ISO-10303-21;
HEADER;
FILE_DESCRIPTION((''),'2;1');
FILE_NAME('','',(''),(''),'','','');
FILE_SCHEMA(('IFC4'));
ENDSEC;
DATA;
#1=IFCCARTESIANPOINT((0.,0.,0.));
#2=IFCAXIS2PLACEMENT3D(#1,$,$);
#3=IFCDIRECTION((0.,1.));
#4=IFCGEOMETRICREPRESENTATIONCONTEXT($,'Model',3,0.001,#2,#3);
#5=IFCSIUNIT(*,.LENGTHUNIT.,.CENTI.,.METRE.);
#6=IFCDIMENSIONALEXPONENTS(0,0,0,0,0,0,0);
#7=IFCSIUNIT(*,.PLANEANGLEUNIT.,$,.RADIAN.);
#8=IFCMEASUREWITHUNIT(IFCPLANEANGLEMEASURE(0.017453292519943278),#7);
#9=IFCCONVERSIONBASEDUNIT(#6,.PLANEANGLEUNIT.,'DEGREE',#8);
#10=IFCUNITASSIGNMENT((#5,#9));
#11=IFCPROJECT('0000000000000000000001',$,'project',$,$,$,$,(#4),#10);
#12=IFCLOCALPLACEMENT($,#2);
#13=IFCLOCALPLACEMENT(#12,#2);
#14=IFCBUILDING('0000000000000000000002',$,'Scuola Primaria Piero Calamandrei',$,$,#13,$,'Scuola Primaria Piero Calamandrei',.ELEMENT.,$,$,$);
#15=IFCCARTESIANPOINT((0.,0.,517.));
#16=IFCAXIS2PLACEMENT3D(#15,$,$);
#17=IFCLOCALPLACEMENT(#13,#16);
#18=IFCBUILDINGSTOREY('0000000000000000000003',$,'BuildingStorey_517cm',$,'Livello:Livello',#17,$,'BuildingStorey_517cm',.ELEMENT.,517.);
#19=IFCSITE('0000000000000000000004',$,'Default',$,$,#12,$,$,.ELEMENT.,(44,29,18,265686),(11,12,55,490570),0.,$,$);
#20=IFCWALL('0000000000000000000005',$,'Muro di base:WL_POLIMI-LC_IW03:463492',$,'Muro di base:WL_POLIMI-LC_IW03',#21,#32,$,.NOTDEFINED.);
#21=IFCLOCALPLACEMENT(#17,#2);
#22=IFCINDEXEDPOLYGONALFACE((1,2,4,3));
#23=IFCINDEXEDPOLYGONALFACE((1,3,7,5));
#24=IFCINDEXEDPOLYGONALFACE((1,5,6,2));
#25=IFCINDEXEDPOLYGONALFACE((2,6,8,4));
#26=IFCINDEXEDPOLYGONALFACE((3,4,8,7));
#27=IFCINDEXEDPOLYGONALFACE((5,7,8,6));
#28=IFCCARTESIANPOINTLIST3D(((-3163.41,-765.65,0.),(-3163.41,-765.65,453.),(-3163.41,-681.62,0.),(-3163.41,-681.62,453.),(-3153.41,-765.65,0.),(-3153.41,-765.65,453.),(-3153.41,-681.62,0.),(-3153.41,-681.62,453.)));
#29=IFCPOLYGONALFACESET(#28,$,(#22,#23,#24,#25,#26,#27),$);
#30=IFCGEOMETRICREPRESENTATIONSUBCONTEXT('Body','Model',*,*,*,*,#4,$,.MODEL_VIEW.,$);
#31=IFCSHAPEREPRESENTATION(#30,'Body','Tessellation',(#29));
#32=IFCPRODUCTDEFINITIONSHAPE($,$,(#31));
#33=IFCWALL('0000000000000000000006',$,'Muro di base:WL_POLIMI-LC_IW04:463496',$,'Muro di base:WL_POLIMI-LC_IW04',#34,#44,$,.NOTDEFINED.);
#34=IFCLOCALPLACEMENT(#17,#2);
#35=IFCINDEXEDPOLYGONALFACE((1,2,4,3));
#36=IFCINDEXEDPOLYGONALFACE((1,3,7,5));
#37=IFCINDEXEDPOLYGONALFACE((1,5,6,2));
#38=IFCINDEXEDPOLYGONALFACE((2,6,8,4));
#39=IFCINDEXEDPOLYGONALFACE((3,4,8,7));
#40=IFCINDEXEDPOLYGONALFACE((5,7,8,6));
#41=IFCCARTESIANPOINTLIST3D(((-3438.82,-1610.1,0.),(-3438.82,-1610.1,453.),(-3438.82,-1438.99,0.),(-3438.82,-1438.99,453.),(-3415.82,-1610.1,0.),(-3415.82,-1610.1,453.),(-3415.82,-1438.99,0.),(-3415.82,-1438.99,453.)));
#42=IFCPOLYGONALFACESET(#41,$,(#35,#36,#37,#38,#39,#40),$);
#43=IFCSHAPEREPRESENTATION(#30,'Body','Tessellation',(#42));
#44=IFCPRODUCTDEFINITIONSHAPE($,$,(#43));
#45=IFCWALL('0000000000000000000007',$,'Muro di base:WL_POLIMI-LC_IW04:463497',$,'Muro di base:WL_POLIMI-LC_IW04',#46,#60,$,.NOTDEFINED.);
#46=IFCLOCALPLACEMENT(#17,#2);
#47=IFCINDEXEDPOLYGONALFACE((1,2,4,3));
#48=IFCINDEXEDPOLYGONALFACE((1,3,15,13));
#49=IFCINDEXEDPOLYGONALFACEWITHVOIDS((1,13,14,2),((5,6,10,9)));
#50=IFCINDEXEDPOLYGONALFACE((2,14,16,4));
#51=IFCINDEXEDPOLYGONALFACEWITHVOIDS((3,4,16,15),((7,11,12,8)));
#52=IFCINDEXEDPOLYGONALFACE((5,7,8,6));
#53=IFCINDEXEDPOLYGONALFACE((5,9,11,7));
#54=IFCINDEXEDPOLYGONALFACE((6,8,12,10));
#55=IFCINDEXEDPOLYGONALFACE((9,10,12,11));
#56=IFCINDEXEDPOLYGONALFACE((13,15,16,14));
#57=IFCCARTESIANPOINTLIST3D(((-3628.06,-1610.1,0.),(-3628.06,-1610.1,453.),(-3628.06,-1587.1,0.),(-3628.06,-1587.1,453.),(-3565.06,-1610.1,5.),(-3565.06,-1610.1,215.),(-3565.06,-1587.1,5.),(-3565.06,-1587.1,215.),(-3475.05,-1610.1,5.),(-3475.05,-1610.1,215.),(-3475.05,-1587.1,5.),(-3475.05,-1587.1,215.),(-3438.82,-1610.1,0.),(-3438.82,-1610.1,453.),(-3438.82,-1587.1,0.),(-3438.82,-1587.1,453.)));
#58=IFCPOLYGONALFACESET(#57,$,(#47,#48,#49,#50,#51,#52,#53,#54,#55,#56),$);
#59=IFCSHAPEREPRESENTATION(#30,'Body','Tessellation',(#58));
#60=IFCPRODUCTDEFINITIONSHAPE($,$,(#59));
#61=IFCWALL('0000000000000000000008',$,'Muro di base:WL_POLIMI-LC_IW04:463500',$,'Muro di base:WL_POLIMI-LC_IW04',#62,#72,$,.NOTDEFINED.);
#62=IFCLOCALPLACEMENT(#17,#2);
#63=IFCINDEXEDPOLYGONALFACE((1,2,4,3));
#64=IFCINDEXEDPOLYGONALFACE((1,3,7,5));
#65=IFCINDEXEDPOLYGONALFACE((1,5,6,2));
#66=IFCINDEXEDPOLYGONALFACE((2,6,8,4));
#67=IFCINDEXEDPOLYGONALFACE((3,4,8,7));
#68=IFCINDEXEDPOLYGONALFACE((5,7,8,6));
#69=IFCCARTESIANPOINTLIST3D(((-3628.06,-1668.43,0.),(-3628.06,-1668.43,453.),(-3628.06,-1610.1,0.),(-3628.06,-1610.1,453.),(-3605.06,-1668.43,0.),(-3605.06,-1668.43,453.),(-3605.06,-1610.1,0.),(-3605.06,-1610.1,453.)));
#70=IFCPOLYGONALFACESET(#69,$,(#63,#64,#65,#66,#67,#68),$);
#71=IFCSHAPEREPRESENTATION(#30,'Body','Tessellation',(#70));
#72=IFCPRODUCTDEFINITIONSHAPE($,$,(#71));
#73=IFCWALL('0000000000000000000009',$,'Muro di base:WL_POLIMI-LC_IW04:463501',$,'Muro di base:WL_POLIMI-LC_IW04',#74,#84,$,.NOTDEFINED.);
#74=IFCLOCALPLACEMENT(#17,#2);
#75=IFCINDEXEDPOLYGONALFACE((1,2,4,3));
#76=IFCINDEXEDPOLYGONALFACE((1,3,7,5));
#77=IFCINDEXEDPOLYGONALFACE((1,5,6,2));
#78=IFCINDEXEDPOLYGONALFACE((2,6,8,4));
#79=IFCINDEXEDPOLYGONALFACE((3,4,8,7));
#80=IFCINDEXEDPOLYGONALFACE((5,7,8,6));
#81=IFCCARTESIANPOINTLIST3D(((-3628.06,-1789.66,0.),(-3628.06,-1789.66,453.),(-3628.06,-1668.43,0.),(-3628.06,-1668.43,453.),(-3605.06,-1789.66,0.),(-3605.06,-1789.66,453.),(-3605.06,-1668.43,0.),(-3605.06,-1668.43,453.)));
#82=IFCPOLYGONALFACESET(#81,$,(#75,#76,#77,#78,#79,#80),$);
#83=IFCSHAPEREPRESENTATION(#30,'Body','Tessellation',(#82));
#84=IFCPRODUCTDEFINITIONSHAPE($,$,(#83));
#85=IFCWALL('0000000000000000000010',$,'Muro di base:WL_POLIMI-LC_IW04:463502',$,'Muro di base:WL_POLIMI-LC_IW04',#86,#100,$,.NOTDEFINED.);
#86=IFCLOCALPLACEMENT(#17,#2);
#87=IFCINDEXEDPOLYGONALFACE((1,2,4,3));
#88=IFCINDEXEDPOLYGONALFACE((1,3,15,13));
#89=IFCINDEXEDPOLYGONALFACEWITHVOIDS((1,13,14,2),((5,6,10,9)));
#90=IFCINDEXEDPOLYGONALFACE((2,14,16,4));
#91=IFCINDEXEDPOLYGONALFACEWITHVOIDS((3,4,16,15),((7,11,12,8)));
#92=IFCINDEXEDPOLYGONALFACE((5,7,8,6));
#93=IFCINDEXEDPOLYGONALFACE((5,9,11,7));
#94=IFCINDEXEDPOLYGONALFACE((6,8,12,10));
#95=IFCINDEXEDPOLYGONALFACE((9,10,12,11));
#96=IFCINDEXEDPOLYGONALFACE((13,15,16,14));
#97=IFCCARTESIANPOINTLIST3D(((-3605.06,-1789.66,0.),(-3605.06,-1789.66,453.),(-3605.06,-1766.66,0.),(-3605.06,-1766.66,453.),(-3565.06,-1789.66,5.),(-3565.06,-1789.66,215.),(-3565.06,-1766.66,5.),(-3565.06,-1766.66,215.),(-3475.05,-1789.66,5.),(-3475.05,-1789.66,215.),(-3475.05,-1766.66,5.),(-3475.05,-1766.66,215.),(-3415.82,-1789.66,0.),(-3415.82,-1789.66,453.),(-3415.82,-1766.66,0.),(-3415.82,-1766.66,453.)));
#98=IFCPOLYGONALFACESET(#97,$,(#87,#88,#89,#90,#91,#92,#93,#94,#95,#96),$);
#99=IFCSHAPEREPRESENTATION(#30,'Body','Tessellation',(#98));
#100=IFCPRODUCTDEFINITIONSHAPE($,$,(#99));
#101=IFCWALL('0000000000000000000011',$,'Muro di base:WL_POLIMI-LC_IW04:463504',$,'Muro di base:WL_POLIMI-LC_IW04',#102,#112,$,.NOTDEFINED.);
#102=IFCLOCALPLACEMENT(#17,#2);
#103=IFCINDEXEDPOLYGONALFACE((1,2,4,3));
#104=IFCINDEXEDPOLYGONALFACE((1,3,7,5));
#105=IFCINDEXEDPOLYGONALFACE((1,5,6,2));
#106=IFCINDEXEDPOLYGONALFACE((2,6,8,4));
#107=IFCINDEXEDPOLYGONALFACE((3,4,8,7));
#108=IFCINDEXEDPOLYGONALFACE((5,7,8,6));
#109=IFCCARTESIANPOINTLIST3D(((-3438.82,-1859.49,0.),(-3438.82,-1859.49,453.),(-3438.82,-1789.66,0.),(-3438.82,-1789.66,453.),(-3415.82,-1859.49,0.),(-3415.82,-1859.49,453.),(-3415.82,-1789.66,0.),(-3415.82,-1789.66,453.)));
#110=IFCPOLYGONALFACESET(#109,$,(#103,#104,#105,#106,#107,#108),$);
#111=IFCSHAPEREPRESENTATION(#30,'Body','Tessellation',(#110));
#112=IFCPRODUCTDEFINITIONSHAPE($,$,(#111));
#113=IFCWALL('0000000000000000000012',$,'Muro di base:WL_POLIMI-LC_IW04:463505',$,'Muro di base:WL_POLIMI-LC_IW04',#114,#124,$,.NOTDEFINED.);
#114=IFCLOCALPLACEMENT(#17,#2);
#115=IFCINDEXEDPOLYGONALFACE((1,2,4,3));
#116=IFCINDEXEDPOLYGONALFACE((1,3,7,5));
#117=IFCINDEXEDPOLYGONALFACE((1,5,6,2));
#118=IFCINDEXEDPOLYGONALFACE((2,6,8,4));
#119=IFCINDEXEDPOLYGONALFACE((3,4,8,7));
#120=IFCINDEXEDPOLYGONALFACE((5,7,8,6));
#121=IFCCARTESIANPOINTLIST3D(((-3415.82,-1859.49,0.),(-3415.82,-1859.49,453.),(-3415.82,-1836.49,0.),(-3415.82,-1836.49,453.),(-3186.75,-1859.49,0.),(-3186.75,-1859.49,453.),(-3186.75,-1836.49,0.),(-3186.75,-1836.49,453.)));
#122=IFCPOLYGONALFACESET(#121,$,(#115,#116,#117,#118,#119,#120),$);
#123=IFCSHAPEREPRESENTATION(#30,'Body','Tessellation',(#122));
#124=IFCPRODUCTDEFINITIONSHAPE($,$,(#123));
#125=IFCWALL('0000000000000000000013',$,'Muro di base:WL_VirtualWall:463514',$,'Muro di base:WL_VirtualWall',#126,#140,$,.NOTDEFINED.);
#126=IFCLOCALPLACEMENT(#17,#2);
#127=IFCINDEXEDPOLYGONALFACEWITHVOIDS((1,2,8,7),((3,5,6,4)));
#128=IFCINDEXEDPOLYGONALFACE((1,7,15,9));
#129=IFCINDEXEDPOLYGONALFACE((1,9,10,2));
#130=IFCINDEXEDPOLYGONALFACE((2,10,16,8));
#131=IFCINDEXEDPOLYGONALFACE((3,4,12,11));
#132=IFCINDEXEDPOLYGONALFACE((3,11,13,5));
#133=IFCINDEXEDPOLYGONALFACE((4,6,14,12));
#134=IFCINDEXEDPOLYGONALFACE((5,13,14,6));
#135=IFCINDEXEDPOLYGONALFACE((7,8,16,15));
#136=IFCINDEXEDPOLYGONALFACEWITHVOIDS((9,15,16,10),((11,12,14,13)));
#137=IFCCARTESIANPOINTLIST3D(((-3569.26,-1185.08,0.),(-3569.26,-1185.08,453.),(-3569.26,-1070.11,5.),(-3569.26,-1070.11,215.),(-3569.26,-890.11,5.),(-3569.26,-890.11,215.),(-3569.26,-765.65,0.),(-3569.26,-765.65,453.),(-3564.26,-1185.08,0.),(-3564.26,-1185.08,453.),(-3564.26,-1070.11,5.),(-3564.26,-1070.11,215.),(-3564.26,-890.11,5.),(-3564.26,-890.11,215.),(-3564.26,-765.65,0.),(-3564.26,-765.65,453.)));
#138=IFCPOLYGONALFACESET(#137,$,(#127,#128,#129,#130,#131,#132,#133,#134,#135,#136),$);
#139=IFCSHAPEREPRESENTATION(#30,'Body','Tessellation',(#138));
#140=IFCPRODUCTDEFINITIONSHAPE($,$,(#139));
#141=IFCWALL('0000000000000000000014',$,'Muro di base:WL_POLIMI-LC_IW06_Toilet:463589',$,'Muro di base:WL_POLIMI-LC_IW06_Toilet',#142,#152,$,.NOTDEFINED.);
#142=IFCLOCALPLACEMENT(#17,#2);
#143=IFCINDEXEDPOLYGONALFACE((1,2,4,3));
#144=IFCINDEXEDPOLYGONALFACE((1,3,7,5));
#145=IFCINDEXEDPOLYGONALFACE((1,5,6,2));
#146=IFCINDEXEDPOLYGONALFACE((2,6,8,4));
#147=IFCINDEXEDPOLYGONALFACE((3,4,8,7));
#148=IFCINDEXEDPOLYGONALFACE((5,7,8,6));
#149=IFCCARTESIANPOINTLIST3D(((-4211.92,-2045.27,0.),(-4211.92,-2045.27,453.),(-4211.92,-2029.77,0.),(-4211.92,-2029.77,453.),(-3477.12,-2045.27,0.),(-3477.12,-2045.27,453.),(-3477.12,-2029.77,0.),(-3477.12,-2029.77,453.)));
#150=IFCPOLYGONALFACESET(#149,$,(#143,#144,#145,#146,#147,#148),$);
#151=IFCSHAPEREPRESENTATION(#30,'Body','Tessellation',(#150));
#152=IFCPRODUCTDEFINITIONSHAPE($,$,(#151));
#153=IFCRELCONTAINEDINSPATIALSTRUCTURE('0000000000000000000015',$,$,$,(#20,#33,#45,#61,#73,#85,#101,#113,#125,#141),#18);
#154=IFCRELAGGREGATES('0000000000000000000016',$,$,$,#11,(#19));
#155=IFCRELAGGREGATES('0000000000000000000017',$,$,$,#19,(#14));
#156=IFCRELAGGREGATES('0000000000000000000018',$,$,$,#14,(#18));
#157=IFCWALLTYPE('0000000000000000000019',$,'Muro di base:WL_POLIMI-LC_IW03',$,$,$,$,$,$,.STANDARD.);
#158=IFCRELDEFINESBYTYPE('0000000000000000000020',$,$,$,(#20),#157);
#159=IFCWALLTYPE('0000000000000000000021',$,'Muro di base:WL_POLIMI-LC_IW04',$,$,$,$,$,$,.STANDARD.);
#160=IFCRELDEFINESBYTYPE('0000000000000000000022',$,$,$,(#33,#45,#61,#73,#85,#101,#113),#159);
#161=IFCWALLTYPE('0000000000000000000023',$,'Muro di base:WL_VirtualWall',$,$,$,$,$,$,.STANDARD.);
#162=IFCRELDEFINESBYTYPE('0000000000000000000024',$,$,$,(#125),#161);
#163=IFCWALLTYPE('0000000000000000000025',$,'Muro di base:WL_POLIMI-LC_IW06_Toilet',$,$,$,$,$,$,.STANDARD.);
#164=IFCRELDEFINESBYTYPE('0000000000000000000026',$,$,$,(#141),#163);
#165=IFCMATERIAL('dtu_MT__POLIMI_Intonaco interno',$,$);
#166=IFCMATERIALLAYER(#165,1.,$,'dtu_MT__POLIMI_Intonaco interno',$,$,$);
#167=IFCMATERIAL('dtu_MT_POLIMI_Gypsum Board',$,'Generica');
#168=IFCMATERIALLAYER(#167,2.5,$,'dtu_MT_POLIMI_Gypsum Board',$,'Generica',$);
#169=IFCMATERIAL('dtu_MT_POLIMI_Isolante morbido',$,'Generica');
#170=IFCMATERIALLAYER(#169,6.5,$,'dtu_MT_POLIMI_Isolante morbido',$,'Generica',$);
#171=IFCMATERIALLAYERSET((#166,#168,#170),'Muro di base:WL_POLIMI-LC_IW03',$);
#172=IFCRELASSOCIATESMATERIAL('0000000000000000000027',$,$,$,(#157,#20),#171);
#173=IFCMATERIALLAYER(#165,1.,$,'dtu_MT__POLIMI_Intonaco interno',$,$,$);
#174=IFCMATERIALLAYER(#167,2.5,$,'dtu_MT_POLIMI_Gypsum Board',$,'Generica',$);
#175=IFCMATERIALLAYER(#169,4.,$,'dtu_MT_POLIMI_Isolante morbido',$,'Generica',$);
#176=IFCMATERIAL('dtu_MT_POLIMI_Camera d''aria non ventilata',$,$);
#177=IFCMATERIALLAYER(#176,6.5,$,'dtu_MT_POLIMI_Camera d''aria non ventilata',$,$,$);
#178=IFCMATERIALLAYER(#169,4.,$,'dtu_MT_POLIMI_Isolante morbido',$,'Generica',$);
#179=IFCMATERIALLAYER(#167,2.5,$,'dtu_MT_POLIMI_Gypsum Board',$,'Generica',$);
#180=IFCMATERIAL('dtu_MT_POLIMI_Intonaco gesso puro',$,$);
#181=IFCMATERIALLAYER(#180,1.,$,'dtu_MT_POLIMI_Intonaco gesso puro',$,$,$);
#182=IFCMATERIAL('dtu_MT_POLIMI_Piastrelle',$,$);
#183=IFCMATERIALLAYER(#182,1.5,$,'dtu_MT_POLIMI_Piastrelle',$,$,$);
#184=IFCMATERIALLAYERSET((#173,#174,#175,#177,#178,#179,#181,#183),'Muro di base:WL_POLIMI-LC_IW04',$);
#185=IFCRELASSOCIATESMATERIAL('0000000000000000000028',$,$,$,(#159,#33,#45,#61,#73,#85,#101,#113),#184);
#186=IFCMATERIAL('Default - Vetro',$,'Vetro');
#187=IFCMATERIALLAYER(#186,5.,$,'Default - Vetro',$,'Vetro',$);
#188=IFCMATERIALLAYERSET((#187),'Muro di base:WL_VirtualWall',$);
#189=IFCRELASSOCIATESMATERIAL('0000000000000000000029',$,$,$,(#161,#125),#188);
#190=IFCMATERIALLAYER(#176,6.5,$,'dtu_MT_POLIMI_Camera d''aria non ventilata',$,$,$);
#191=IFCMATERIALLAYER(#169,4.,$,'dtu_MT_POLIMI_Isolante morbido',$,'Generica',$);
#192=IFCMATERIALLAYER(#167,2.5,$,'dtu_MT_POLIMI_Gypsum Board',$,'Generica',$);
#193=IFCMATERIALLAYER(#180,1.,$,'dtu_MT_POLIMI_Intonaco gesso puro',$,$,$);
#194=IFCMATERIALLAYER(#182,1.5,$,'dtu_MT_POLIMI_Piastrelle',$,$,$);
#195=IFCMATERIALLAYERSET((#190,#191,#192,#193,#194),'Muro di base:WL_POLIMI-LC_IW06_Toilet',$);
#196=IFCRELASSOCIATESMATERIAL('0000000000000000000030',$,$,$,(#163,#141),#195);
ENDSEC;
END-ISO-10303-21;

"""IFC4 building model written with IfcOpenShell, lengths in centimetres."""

from ifc_helpers import new_model, entity, si_unit, converted_unit, direction, frame, frame_2d, origin, place, context, subcontext, project, spatial, rectangle, extrude, material, layer, layer_set, layer_usage, type_object, element, save


model = new_model("IFC4")

# Units and contexts
model_context = context("Model", 3, precision=0.001, world=origin(), true_north=direction((0.0, 1.0)))
body_context = subcontext(model_context, "Body", "Model", "MODEL_VIEW")
ifc_project = project(units=[si_unit("LENGTHUNIT", "METRE", prefix="CENTI"), converted_unit("PLANEANGLEUNIT", "DEGREE", entity("IfcPlaneAngleMeasure", 0.017453292519943278), si_unit("PLANEANGLEUNIT", "RADIAN"), dimensions=[0, 0, 0, 0, 0, 0, 0])], contexts=[model_context])

# Site, building, storey
site_placement = place(None, origin())
site = spatial("IfcSite", under=ifc_project, at=site_placement, Name="Default", CompositionType="ELEMENT", RefLatitude=(44, 29, 18, 265686), RefLongitude=(11, 12, 55, 490570), RefElevation=0.0)
building_placement = place(site_placement, origin())
building = spatial("IfcBuilding", under=site, at=building_placement, Name="Scuola Primaria Piero Calamandrei", LongName="Scuola Primaria Piero Calamandrei", CompositionType="ELEMENT")
storey_placement = place(building_placement, frame((0.0, 0.0, 517.0)))
storey = spatial("IfcBuildingStorey", under=building, at=storey_placement, Name="BuildingStorey_517cm", ObjectType="Livello:Livello", LongName="BuildingStorey_517cm", CompositionType="ELEMENT", Elevation=517.0)

# Shared definitions
ifc_material_1 = material(Name="dtu_MT_POLIMI_Isolante morbido", Category="Generica")
ifc_material_2 = material(Name="dtu_MT_POLIMI_Gypsum Board", Category="Generica")
ifc_material_3 = material(Name="dtu_MT__POLIMI_Intonaco interno")

# Shared definitions
ifc_material_4 = material(Name="dtu_MT_POLIMI_Camera d'aria non ventilata")
ifc_material_5 = material(Name="dtu_MT_POLIMI_Intonaco gesso puro")

# Walls
ifc_layer_1 = layer(ifc_material_3, 1.0, Name="dtu_MT__POLIMI_Intonaco interno")
ifc_layer_2 = layer(ifc_material_2, 2.5, Name="dtu_MT_POLIMI_Gypsum Board", Category="Generica")
ifc_layer_3 = layer(ifc_material_1, 6.5, Name="dtu_MT_POLIMI_Isolante morbido", Category="Generica")
ifc_layer_set_1 = layer_set([ifc_layer_1, ifc_layer_2, ifc_layer_3], Name="Muro di base:WL_POLIMI-LC_IW03")
wall_type_1 = type_object("IfcWallType", Name="Muro di base:WL_POLIMI-LC_IW03", PredefinedType="STANDARD", material=ifc_layer_set_1)
ifc_layer_usage_1 = layer_usage(ifc_layer_set_1, "AXIS2", "NEGATIVE", 5.0)
wall_1_placement = place(storey_placement, frame((-3158.41, -765.65, 0.0), z_axis=(0.0, 0.0, 1.0), x_axis=(0.0, 1.0, 0.0)))
element("IfcWall", 1, at=wall_1_placement, inside=storey, type_object=wall_type_1, material=ifc_layer_usage_1, Name="Muro di base:WL_POLIMI-LC_IW03:463492", ObjectType="Muro di base:WL_POLIMI-LC_IW03", PredefinedType="NOTDEFINED", context=body_context, shape_type="SweptSolid", body=[
    extrude(rectangle(XDim=84.03, YDim=10.0, at=frame_2d((42.02, 0.0), x_axis=(-1.0, 0.0))), origin(), (0.0, 0.0, 1.0), 453.0),
])
ifc_layer_4 = layer(ifc_material_3, 1.0, Name="dtu_MT__POLIMI_Intonaco interno")
ifc_layer_5 = layer(ifc_material_2, 2.5, Name="dtu_MT_POLIMI_Gypsum Board", Category="Generica")
ifc_layer_6 = layer(ifc_material_1, 4.0, Name="dtu_MT_POLIMI_Isolante morbido", Category="Generica")
ifc_layer_7 = layer(ifc_material_4, 6.5, Name="dtu_MT_POLIMI_Camera d'aria non ventilata")
ifc_layer_8 = layer(ifc_material_1, 4.0, Name="dtu_MT_POLIMI_Isolante morbido", Category="Generica")
ifc_layer_9 = layer(ifc_material_2, 2.5, Name="dtu_MT_POLIMI_Gypsum Board", Category="Generica")
ifc_layer_10 = layer(ifc_material_5, 1.0, Name="dtu_MT_POLIMI_Intonaco gesso puro")
ifc_material_6 = material(Name="dtu_MT_POLIMI_Piastrelle")
ifc_layer_11 = layer(ifc_material_6, 1.5, Name="dtu_MT_POLIMI_Piastrelle")
ifc_layer_set_2 = layer_set([ifc_layer_4, ifc_layer_5, ifc_layer_6, ifc_layer_7, ifc_layer_8, ifc_layer_9, ifc_layer_10, ifc_layer_11], Name="Muro di base:WL_POLIMI-LC_IW04")
ifc_layer_usage_2 = layer_usage(ifc_layer_set_2, "AXIS2", "NEGATIVE", 11.5)
wall_type_2 = type_object("IfcWallType", Name="Muro di base:WL_POLIMI-LC_IW04", PredefinedType="STANDARD", material=ifc_layer_set_2)
wall_2_placement = place(storey_placement, frame((-3427.32, -1610.1, 0.0), z_axis=(0.0, 0.0, 1.0), x_axis=(0.0, 1.0, 0.0)))
element("IfcWall", 2, at=wall_2_placement, inside=storey, type_object=wall_type_2, material=ifc_layer_usage_2, Name="Muro di base:WL_POLIMI-LC_IW04:463496", ObjectType="Muro di base:WL_POLIMI-LC_IW04", PredefinedType="NOTDEFINED", context=body_context, shape_type="SweptSolid", body=[
    extrude(rectangle(XDim=171.11, YDim=23.0, at=frame_2d((85.55, 0.0), x_axis=(-1.0, 0.0))), origin(), (0.0, 0.0, 1.0), 453.0),
])

# Wall, opening
ifc_layer_usage_3 = layer_usage(ifc_layer_set_2, "AXIS2", "NEGATIVE", 11.5)
wall_3_placement = place(storey_placement, frame((-3628.06, -1598.6, 0.0)))
wall_3 = element("IfcWall", 3, at=wall_3_placement, inside=storey, type_object=wall_type_2, material=ifc_layer_usage_3, Name="Muro di base:WL_POLIMI-LC_IW04:463497", ObjectType="Muro di base:WL_POLIMI-LC_IW04", PredefinedType="NOTDEFINED", context=body_context, shape_type="SweptSolid", body=[
    extrude(rectangle(XDim=189.23, YDim=23.0, at=frame_2d((94.62, 0.0), x_axis=(-1.0, 0.0))), origin(), (0.0, 0.0, 1.0), 453.0),
])
opening_1_placement = place(wall_3_placement, frame((153.0, 11.5, 5.0)))
element("IfcOpeningElement", 4, at=opening_1_placement, cuts=wall_3, PredefinedType="OPENING", context=body_context, shape_type="SweptSolid", body=[
    extrude(rectangle(XDim=210.0, YDim=90.0, at=frame_2d((105.0, 45.0), x_axis=(-1.0, 0.0))), frame((0.0, 0.0, 0.0), z_axis=(0.0, -1.0, 0.0), x_axis=(0.0, 0.0, 1.0)), (0.0, 0.0, 1.0), 23.0),
])

# Walls
ifc_layer_usage_4 = layer_usage(ifc_layer_set_2, "AXIS2", "NEGATIVE", 11.5)
wall_4_placement = place(storey_placement, frame((-3616.56, -1668.43, 0.0), z_axis=(0.0, 0.0, 1.0), x_axis=(0.0, 1.0, 0.0)))
element("IfcWall", 5, at=wall_4_placement, inside=storey, type_object=wall_type_2, material=ifc_layer_usage_4, Name="Muro di base:WL_POLIMI-LC_IW04:463500", ObjectType="Muro di base:WL_POLIMI-LC_IW04", PredefinedType="NOTDEFINED", context=body_context, shape_type="SweptSolid", body=[
    extrude(rectangle(XDim=58.33, YDim=23.0, at=frame_2d((29.16, 0.0), x_axis=(-1.0, 0.0))), origin(), (0.0, 0.0, 1.0), 453.0),
])
ifc_layer_usage_5 = layer_usage(ifc_layer_set_2, "AXIS2", "NEGATIVE", 11.5)
wall_5_placement = place(storey_placement, frame((-3616.56, -1789.66, 0.0), z_axis=(0.0, 0.0, 1.0), x_axis=(0.0, 1.0, 0.0)))
element("IfcWall", 6, at=wall_5_placement, inside=storey, type_object=wall_type_2, material=ifc_layer_usage_5, Name="Muro di base:WL_POLIMI-LC_IW04:463501", ObjectType="Muro di base:WL_POLIMI-LC_IW04", PredefinedType="NOTDEFINED", context=body_context, shape_type="SweptSolid", body=[
    extrude(rectangle(XDim=121.23, YDim=23.0, at=frame_2d((60.62, 0.0), x_axis=(-1.0, 0.0))), origin(), (0.0, 0.0, 1.0), 453.0),
])

# Wall, opening
ifc_layer_usage_6 = layer_usage(ifc_layer_set_2, "AXIS2", "NEGATIVE", 11.5)
wall_6_placement = place(storey_placement, frame((-3415.82, -1778.16, 0.0), z_axis=(0.0, 0.0, 1.0), x_axis=(-1.0, 0.0, 0.0)))
wall_6 = element("IfcWall", 7, at=wall_6_placement, inside=storey, type_object=wall_type_2, material=ifc_layer_usage_6, Name="Muro di base:WL_POLIMI-LC_IW04:463502", ObjectType="Muro di base:WL_POLIMI-LC_IW04", PredefinedType="NOTDEFINED", context=body_context, shape_type="SweptSolid", body=[
    extrude(rectangle(XDim=189.23, YDim=23.0, at=frame_2d((94.62, 0.0), x_axis=(-1.0, 0.0))), origin(), (0.0, 0.0, 1.0), 453.0),
])
opening_2_placement = place(wall_6_placement, frame((149.23, 11.5, 5.0)))
element("IfcOpeningElement", 8, at=opening_2_placement, cuts=wall_6, PredefinedType="OPENING", context=body_context, shape_type="SweptSolid", body=[
    extrude(rectangle(XDim=210.0, YDim=90.0, at=frame_2d((105.0, 45.0), x_axis=(-1.0, 0.0))), frame((0.0, 0.0, 0.0), z_axis=(0.0, -1.0, 0.0), x_axis=(0.0, 0.0, 1.0)), (0.0, 0.0, 1.0), 23.0),
])

# Walls
ifc_layer_usage_7 = layer_usage(ifc_layer_set_2, "AXIS2", "NEGATIVE", 11.5)
wall_7_placement = place(storey_placement, frame((-3427.32, -1859.49, 0.0), z_axis=(0.0, 0.0, 1.0), x_axis=(0.0, 1.0, 0.0)))
element("IfcWall", 9, at=wall_7_placement, inside=storey, type_object=wall_type_2, material=ifc_layer_usage_7, Name="Muro di base:WL_POLIMI-LC_IW04:463504", ObjectType="Muro di base:WL_POLIMI-LC_IW04", PredefinedType="NOTDEFINED", context=body_context, shape_type="SweptSolid", body=[
    extrude(rectangle(XDim=69.83, YDim=23.0, at=frame_2d((34.91, 0.0), x_axis=(-1.0, 0.0))), origin(), (0.0, 0.0, 1.0), 453.0),
])
ifc_layer_usage_8 = layer_usage(ifc_layer_set_2, "AXIS2", "NEGATIVE", 11.5)
wall_8_placement = place(storey_placement, frame((-3186.75, -1847.99, 0.0), z_axis=(0.0, 0.0, 1.0), x_axis=(-1.0, 0.0, 0.0)))
element("IfcWall", 10, at=wall_8_placement, inside=storey, type_object=wall_type_2, material=ifc_layer_usage_8, Name="Muro di base:WL_POLIMI-LC_IW04:463505", ObjectType="Muro di base:WL_POLIMI-LC_IW04", PredefinedType="NOTDEFINED", context=body_context, shape_type="SweptSolid", body=[
    extrude(rectangle(XDim=229.07, YDim=23.0, at=frame_2d((114.54, 0.0), x_axis=(-1.0, 0.0))), origin(), (0.0, 0.0, 1.0), 453.0),
])

# Wall, opening
ifc_material_7 = material(Name="Default - Vetro", Category="Vetro")
ifc_layer_12 = layer(ifc_material_7, 5.0, Name="Default - Vetro", Category="Vetro")
ifc_layer_set_3 = layer_set([ifc_layer_12], Name="Muro di base:WL_VirtualWall")
ifc_layer_usage_9 = layer_usage(ifc_layer_set_3, "AXIS2", "NEGATIVE", 2.5)
wall_type_3 = type_object("IfcWallType", Name="Muro di base:WL_VirtualWall", PredefinedType="STANDARD", material=ifc_layer_set_3)
wall_9_placement = place(storey_placement, frame((-3566.76, -1185.08, 0.0), z_axis=(0.0, 0.0, 1.0), x_axis=(0.0, 1.0, 0.0)))
wall_9 = element("IfcWall", 11, at=wall_9_placement, inside=storey, type_object=wall_type_3, material=ifc_layer_usage_9, Name="Muro di base:WL_VirtualWall:463514", ObjectType="Muro di base:WL_VirtualWall", PredefinedType="NOTDEFINED", context=body_context, shape_type="SweptSolid", body=[
    extrude(rectangle(XDim=419.42, YDim=5.0, at=frame_2d((209.71, 0.0), x_axis=(-1.0, 0.0))), origin(), (0.0, 0.0, 1.0), 453.0),
])
opening_3_placement = place(wall_9_placement, frame((114.96, -2.5, 5.0)))
element("IfcOpeningElement", 12, at=opening_3_placement, cuts=wall_9, PredefinedType="OPENING", context=body_context, shape_type="SweptSolid", body=[
    extrude(rectangle(XDim=210.0, YDim=180.0, at=frame_2d((105.0, 90.0), x_axis=(1.0, 0.0))), frame((0.0, 0.0, 0.0), z_axis=(0.0, 1.0, 0.0), x_axis=(0.0, 0.0, 1.0)), (0.0, 0.0, 1.0), 5.0),
])

# Wall
ifc_layer_13 = layer(ifc_material_4, 6.5, Name="dtu_MT_POLIMI_Camera d'aria non ventilata")
ifc_layer_14 = layer(ifc_material_1, 4.0, Name="dtu_MT_POLIMI_Isolante morbido", Category="Generica")
ifc_layer_15 = layer(ifc_material_2, 2.5, Name="dtu_MT_POLIMI_Gypsum Board", Category="Generica")
ifc_layer_16 = layer(ifc_material_5, 1.0, Name="dtu_MT_POLIMI_Intonaco gesso puro")
ifc_layer_17 = layer(ifc_material_6, 1.5, Name="dtu_MT_POLIMI_Piastrelle")
ifc_layer_set_4 = layer_set([ifc_layer_13, ifc_layer_14, ifc_layer_15, ifc_layer_16, ifc_layer_17], Name="Muro di base:WL_POLIMI-LC_IW06_Toilet")
wall_type_4 = type_object("IfcWallType", Name="Muro di base:WL_POLIMI-LC_IW06_Toilet", PredefinedType="STANDARD", material=ifc_layer_set_4)
ifc_layer_usage_10 = layer_usage(ifc_layer_set_4, "AXIS2", "NEGATIVE", 7.75)
wall_10_placement = place(storey_placement, frame((-3477.12, -2037.52, 0.0), z_axis=(0.0, 0.0, 1.0), x_axis=(-1.0, 0.0, 0.0)))
element("IfcWall", 13, at=wall_10_placement, inside=storey, type_object=wall_type_4, material=ifc_layer_usage_10, Name="Muro di base:WL_POLIMI-LC_IW06_Toilet:463589", ObjectType="Muro di base:WL_POLIMI-LC_IW06_Toilet", PredefinedType="NOTDEFINED", context=body_context, shape_type="SweptSolid", body=[
    extrude(rectangle(XDim=734.8, YDim=15.5, at=frame_2d((367.4, 0.0), x_axis=(-1.0, 0.0))), origin(), (0.0, 0.0, 1.0), 453.0),
])

save(model, "model.ifc")
